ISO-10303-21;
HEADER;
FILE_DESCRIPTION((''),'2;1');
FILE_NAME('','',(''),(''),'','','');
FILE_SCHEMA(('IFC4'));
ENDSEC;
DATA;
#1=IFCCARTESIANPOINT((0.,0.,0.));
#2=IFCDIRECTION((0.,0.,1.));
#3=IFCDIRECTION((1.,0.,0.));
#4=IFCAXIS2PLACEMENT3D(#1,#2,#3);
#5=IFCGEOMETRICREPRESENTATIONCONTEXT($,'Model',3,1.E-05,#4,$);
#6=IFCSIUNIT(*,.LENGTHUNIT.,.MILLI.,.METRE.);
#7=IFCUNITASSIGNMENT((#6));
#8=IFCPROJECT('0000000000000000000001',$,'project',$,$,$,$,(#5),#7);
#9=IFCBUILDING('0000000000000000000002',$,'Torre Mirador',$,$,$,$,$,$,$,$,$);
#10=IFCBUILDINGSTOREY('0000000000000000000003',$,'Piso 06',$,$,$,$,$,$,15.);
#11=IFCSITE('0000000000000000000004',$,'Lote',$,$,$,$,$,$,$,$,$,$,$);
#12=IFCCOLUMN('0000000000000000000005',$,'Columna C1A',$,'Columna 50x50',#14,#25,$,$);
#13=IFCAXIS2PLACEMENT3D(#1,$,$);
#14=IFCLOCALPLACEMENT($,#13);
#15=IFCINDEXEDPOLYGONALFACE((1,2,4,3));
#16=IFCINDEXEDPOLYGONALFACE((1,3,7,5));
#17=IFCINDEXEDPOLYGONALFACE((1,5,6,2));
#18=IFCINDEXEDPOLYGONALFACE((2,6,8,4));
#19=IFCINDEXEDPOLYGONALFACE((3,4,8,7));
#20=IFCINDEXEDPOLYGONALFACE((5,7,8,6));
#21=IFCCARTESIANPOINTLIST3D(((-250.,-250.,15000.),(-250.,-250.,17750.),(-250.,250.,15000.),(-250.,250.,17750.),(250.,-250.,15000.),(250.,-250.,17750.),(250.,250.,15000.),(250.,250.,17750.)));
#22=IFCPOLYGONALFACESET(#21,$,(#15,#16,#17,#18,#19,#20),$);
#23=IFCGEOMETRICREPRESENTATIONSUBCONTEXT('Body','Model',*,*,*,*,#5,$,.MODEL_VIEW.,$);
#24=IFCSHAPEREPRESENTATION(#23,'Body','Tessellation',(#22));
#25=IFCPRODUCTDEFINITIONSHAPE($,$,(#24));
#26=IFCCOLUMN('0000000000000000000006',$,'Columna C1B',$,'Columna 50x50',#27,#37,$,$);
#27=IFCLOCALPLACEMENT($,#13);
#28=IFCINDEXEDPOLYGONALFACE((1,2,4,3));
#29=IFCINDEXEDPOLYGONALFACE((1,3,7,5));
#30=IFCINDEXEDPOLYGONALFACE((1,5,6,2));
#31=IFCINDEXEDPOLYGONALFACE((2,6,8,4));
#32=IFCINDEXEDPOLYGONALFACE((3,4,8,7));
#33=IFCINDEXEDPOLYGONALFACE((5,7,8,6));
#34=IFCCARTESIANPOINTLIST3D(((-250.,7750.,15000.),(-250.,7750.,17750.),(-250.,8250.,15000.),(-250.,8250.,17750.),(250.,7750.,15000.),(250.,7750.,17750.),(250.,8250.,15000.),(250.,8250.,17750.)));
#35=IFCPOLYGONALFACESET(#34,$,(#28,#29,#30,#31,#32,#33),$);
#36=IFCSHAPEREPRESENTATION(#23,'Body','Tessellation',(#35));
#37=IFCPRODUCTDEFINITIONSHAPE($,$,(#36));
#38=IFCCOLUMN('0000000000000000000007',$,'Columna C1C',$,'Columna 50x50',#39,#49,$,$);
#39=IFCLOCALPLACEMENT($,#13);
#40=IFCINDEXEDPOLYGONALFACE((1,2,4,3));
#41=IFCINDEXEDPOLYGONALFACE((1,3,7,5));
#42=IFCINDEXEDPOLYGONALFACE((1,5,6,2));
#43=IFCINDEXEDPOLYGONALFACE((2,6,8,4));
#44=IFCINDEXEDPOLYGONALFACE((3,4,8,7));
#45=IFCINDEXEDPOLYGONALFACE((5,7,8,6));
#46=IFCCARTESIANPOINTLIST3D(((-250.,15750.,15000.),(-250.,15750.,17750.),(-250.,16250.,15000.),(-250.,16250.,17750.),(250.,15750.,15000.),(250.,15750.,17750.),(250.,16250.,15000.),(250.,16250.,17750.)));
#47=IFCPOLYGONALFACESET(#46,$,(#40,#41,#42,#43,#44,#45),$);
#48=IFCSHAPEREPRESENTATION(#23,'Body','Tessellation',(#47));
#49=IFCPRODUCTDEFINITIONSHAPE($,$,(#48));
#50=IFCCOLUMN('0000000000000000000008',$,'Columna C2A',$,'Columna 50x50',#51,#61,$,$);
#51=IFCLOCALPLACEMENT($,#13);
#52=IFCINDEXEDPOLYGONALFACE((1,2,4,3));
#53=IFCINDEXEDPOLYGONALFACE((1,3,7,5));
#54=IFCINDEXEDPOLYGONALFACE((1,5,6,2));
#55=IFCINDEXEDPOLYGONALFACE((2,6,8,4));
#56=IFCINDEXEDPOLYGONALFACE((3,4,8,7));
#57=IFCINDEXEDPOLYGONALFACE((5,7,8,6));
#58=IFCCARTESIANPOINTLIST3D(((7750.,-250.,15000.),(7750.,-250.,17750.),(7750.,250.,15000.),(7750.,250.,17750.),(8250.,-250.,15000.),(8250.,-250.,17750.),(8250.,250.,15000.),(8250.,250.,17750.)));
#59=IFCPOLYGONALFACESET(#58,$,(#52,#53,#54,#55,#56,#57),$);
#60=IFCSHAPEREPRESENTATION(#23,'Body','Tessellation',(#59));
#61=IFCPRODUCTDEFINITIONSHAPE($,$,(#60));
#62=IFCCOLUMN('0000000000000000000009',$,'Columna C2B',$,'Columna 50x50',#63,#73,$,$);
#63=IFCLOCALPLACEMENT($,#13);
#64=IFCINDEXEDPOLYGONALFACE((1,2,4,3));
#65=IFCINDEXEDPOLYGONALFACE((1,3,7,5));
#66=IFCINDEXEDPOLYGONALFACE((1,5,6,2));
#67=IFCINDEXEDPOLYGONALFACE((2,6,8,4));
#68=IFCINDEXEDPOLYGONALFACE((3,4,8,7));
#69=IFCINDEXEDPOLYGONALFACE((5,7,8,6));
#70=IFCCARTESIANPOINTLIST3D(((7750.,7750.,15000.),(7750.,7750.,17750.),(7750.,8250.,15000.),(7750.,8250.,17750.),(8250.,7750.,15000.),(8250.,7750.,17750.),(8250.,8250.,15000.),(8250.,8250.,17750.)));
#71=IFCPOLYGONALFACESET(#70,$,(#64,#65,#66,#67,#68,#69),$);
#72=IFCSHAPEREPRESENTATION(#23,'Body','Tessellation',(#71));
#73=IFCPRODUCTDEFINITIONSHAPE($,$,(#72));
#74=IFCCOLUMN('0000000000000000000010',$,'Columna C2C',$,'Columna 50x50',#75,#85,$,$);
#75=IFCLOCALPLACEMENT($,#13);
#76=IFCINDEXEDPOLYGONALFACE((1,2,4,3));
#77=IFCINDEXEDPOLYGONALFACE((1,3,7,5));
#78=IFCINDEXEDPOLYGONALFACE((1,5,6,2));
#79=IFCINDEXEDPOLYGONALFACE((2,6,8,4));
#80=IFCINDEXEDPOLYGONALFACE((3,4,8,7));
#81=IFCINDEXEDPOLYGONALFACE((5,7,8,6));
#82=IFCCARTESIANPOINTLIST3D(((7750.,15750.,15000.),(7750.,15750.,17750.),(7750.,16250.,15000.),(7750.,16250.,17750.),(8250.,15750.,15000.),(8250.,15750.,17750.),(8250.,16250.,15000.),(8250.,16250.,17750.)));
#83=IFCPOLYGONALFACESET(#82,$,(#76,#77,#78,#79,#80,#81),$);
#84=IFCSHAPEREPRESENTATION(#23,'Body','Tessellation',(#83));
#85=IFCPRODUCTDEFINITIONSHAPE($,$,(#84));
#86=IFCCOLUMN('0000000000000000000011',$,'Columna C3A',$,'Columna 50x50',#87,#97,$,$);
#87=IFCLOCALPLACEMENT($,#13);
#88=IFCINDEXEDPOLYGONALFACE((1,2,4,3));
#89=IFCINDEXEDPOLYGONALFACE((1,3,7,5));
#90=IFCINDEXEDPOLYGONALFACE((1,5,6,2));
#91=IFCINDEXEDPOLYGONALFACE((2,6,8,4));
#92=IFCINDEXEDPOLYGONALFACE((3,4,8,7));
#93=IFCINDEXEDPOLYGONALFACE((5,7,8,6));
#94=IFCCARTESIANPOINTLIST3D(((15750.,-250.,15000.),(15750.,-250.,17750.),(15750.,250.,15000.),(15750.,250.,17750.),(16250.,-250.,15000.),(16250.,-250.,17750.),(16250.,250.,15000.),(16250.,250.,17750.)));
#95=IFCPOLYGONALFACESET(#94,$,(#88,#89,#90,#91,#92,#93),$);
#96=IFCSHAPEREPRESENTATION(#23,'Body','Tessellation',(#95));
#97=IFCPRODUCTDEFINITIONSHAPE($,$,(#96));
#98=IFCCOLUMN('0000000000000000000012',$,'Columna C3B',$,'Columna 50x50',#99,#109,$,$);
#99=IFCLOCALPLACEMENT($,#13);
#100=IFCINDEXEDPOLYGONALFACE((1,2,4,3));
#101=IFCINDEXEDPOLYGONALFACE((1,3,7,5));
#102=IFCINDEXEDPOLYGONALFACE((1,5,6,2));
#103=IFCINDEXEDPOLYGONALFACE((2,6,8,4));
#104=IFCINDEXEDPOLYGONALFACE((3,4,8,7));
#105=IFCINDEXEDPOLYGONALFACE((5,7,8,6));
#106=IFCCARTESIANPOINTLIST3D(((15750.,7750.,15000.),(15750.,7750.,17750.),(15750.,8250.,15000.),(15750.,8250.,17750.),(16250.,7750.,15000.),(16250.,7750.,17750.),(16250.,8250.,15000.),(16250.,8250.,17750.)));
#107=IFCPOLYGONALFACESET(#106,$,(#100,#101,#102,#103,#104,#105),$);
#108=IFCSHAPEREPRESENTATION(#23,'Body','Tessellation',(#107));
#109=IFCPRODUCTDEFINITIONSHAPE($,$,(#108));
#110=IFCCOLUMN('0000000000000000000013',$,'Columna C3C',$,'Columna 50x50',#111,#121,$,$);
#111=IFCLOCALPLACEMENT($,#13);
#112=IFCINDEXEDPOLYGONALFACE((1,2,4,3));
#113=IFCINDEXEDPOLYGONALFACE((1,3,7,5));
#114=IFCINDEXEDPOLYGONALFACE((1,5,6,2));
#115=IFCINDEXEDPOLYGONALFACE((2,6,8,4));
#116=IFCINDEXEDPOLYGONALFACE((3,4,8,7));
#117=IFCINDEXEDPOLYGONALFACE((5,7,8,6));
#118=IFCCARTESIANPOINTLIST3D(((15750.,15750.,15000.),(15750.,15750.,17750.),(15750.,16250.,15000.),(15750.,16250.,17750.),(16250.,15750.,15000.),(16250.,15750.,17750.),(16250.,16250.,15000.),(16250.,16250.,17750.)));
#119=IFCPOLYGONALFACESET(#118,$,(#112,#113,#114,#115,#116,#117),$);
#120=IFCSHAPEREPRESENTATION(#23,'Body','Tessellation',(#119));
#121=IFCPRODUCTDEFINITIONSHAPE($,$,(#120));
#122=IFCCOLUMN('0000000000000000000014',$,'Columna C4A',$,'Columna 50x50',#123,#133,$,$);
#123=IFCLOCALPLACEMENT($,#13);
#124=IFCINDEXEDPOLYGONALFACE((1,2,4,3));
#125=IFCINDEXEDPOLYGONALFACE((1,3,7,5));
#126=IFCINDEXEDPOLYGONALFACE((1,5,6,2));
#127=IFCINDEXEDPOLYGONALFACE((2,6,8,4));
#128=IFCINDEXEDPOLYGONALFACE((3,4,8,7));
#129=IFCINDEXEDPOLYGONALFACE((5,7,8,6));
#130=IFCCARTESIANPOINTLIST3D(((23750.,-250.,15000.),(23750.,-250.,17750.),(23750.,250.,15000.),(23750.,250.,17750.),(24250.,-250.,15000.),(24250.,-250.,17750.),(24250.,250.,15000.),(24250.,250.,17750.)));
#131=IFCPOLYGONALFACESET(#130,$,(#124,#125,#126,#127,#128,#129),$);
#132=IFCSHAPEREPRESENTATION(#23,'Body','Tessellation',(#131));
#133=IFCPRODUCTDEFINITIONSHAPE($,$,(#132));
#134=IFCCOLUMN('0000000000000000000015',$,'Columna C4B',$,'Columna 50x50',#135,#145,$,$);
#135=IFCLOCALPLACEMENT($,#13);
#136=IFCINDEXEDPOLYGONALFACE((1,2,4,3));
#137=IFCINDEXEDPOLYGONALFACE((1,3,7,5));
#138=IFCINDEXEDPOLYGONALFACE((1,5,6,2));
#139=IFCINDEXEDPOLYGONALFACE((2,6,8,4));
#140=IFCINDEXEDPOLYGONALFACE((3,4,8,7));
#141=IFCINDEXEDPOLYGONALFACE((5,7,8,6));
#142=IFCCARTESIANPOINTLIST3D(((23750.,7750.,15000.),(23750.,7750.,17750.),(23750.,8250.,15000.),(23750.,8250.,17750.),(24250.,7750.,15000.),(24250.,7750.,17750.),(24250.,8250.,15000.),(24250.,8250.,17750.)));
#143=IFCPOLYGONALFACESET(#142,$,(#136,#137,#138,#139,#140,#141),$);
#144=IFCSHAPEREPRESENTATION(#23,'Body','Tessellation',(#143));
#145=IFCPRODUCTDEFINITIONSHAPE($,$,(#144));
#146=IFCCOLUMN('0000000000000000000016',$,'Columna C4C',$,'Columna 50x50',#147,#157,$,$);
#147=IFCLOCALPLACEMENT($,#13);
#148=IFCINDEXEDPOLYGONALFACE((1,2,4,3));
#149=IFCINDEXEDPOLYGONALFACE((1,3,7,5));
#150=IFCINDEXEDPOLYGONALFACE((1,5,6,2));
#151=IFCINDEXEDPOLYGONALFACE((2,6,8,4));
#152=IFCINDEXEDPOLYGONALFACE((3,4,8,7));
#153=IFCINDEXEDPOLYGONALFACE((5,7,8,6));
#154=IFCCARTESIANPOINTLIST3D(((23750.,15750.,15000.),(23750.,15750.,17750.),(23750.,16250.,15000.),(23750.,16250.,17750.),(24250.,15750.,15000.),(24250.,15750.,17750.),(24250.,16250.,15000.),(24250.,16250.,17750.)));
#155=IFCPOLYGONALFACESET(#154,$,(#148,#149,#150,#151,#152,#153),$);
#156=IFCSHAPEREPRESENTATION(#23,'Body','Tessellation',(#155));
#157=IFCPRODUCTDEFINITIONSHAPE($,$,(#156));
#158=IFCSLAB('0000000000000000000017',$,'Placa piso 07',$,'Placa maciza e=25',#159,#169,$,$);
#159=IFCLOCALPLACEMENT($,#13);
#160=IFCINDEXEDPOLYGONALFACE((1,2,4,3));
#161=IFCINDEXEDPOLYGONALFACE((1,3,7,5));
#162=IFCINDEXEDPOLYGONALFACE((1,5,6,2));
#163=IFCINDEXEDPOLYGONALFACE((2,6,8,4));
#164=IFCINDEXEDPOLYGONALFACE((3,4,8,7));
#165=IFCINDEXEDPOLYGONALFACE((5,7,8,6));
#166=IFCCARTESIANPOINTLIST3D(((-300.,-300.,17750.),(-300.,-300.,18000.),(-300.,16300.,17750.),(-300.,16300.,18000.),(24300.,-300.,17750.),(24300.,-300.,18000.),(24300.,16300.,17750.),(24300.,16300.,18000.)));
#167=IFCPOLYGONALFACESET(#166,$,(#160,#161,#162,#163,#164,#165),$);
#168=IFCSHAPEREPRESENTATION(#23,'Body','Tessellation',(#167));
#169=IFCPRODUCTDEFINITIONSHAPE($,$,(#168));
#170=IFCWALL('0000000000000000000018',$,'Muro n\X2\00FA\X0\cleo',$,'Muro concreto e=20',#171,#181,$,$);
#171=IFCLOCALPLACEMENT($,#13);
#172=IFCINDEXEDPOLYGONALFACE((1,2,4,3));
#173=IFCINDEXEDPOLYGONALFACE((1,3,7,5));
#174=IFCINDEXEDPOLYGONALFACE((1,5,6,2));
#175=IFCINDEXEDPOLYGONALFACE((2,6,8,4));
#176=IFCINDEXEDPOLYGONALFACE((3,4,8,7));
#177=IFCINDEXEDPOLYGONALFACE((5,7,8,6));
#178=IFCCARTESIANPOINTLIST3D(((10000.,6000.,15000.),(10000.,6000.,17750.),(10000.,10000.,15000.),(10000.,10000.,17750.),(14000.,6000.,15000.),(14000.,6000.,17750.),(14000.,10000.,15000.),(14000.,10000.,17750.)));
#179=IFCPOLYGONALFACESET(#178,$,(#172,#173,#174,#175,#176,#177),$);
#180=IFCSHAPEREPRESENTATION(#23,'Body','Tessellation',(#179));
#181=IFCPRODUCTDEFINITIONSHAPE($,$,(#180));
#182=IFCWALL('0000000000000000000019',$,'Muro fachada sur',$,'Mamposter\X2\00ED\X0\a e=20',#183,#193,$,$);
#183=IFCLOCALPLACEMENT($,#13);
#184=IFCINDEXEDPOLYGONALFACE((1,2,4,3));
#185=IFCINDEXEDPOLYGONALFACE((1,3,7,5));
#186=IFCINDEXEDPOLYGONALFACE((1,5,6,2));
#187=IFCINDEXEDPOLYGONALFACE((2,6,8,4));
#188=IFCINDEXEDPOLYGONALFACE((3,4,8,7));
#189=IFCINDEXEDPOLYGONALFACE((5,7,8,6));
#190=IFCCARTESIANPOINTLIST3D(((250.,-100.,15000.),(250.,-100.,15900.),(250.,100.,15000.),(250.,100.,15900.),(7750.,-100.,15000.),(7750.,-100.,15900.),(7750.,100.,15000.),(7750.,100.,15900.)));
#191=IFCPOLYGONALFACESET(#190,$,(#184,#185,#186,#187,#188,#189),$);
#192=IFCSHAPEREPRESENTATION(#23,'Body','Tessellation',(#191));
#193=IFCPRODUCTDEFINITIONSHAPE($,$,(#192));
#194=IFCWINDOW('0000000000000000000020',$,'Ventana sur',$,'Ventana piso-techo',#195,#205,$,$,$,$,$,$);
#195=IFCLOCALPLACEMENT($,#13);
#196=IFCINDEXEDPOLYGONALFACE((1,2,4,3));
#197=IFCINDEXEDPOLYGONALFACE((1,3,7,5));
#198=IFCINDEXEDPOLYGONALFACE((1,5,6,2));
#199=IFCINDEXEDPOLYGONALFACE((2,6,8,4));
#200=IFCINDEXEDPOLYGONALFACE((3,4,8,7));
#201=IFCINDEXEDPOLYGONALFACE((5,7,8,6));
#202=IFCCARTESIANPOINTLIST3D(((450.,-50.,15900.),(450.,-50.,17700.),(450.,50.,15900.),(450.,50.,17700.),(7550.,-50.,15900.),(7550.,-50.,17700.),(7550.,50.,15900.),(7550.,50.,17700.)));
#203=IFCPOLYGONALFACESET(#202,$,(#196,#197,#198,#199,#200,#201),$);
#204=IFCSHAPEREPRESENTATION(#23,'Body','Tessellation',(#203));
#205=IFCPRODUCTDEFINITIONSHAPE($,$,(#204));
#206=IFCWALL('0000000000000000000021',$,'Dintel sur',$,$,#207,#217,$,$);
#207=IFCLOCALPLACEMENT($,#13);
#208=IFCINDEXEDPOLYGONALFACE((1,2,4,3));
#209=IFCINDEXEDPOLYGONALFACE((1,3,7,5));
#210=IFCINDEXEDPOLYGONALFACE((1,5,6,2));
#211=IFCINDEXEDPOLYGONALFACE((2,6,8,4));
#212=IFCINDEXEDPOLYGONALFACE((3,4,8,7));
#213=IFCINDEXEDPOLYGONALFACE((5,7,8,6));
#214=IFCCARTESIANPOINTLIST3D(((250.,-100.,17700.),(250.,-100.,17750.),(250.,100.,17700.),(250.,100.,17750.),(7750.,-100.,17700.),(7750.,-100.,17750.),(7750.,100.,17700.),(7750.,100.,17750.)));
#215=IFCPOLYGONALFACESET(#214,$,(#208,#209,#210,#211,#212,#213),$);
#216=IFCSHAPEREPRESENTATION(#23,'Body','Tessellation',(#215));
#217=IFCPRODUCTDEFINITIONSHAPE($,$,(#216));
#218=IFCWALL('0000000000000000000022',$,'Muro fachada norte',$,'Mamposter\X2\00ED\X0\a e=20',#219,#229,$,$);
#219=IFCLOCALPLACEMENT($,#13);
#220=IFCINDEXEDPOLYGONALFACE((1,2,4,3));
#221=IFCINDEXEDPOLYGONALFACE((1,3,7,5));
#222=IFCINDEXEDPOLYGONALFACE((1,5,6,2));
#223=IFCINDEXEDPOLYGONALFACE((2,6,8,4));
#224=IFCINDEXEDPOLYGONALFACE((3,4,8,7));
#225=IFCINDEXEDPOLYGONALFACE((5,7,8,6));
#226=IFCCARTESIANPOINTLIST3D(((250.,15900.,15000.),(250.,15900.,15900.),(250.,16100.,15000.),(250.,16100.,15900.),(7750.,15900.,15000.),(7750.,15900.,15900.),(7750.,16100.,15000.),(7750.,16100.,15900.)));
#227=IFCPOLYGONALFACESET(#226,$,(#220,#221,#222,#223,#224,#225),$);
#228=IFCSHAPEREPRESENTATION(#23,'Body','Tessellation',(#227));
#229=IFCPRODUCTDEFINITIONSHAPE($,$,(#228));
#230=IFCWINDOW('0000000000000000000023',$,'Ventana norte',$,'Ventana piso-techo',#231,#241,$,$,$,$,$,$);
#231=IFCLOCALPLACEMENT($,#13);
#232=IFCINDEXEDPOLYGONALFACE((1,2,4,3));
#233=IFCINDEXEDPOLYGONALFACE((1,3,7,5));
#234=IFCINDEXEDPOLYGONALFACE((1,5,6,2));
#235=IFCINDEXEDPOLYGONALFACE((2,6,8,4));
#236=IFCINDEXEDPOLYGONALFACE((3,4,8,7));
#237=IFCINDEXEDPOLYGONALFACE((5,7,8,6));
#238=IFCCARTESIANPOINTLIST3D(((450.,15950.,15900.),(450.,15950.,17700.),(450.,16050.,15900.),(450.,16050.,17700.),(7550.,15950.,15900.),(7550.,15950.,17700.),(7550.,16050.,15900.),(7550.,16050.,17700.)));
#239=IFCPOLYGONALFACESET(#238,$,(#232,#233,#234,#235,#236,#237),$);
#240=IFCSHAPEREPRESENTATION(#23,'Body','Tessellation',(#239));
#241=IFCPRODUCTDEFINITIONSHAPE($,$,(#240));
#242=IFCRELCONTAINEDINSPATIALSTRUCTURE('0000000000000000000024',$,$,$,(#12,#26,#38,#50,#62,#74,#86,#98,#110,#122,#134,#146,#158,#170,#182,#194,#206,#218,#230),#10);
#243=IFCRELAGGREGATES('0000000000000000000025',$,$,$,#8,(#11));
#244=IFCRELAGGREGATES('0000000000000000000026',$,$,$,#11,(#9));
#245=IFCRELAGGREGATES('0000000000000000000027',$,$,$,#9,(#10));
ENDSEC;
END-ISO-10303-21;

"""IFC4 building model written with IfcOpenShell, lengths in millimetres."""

from ifc_helpers import new_model, si_unit, frame, origin_with_axes, place, context, subcontext, project, spatial, indexed_curve, outline, extrude, element, save


model = new_model("IFC4")

# Units and contexts
model_context = context("Model", 3, precision=1e-05, world=origin_with_axes())
body_context = subcontext(model_context, "Body", "Model", "MODEL_VIEW")
ifc_project = project(units=[si_unit("LENGTHUNIT", "METRE", prefix="MILLI")], contexts=[model_context])

# Site, building, storey
site = spatial("IfcSite", under=ifc_project, Name="Lote")
building = spatial("IfcBuilding", under=site, Name="Torre Mirador")
storey = spatial("IfcBuildingStorey", under=building, Name="Piso 06", Elevation=15.0)

# Columns
for number, where, z_axis, x_axis, name in (
    (1, (-250.0, -250.0, 15000.0), (0.0, 0.0, 1.0), (1.0, 0.0, 0.0), "Columna C1A"),
    (2, (-250.0, 7750.0, 15000.0), (0.0, 0.0, 1.0), (1.0, 0.0, 0.0), "Columna C1B"),
    (3, (-250.0, 15750.0, 15000.0), (0.0, 0.0, 1.0), (1.0, 0.0, 0.0), "Columna C1C"),
    (4, (7750.0, -250.0, 15000.0), (0.0, 0.0, 1.0), (1.0, 0.0, 0.0), "Columna C2A"),
    (5, (7750.0, 7750.0, 15000.0), (0.0, 0.0, 1.0), (1.0, 0.0, 0.0), "Columna C2B"),
    (6, (7750.0, 15750.0, 15000.0), (0.0, 0.0, 1.0), (1.0, 0.0, 0.0), "Columna C2C"),
    (7, (15750.0, -250.0, 15000.0), (0.0, 0.0, 1.0), (1.0, 0.0, 0.0), "Columna C3A"),
    (8, (15750.0, 7750.0, 15000.0), (0.0, 0.0, 1.0), (1.0, 0.0, 0.0), "Columna C3B"),
    (9, (15750.0, 15750.0, 15000.0), (0.0, 0.0, 1.0), (1.0, 0.0, 0.0), "Columna C3C"),
    (10, (23750.0, -250.0, 15000.0), (0.0, 0.0, 1.0), (1.0, 0.0, 0.0), "Columna C4A"),
    (11, (23750.0, 7750.0, 15000.0), (0.0, 0.0, 1.0), (1.0, 0.0, 0.0), "Columna C4B"),
    (12, (23750.0, 15750.0, 15000.0), (0.0, 0.0, 1.0), (1.0, 0.0, 0.0), "Columna C4C"),
):
    element("IfcColumn", number, at=place(None, frame(where, z_axis=z_axis, x_axis=x_axis)), inside=storey, Name=name, ObjectType="Columna 50x50", context=body_context, shape_type="SweptSolid", body=[
        extrude(outline(indexed_curve([(0.0, 0.0), (0.0, 500.0), (500.0, 500.0), (500.0, 0.0), (0.0, 0.0)], self_intersect=False)), origin_with_axes(), (0.0, 0.0, 1.0), 2750.0),
    ])

# Slab
slab_placement = place(None, frame((-300.0, -300.0, 17750.0), z_axis=(0.0, 0.0, 1.0), x_axis=(1.0, 0.0, 0.0)))
element("IfcSlab", 13, at=slab_placement, inside=storey, Name="Placa piso 07", ObjectType="Placa maciza e=25", context=body_context, shape_type="SweptSolid", body=[
    extrude(outline(indexed_curve([(0.0, 0.0), (0.0, 16600.0), (24600.0, 16600.0), (24600.0, 0.0), (0.0, 0.0)], self_intersect=False)), origin_with_axes(), (0.0, 0.0, 1.0), 250.0),
])

# Walls
wall_1_placement = place(None, frame((10000.0, 6000.0, 15000.0), z_axis=(0.0, 0.0, 1.0), x_axis=(1.0, 0.0, 0.0)))
element("IfcWall", 14, at=wall_1_placement, inside=storey, Name="Muro núcleo", ObjectType="Muro concreto e=20", context=body_context, shape_type="SweptSolid", body=[
    extrude(outline(indexed_curve([(0.0, 0.0), (0.0, 4000.0), (4000.0, 4000.0), (4000.0, 0.0), (0.0, 0.0)], self_intersect=False)), origin_with_axes(), (0.0, 0.0, 1.0), 2750.0),
])
wall_2_placement = place(None, frame((250.0, -100.0, 15000.0), z_axis=(0.0, 0.0, 1.0), x_axis=(1.0, 0.0, 0.0)))
element("IfcWall", 15, at=wall_2_placement, inside=storey, Name="Muro fachada sur", ObjectType="Mampostería e=20", context=body_context, shape_type="SweptSolid", body=[
    extrude(outline(indexed_curve([(0.0, 0.0), (0.0, 200.0), (7500.0, 200.0), (7500.0, 0.0), (0.0, 0.0)], self_intersect=False)), origin_with_axes(), (0.0, 0.0, 1.0), 900.0),
])

# Window
window_1_placement = place(None, frame((450.0, -50.0, 15900.0), z_axis=(0.0, 0.0, 1.0), x_axis=(1.0, 0.0, 0.0)))
element("IfcWindow", 16, at=window_1_placement, inside=storey, Name="Ventana sur", ObjectType="Ventana piso-techo", context=body_context, shape_type="SweptSolid", body=[
    extrude(outline(indexed_curve([(0.0, 0.0), (0.0, 100.0), (7100.0, 100.0), (7100.0, 0.0), (0.0, 0.0)], self_intersect=False)), origin_with_axes(), (0.0, 0.0, 1.0), 1800.0),
])

# Walls
wall_3_placement = place(None, frame((250.0, -100.0, 17700.0), z_axis=(0.0, 0.0, 1.0), x_axis=(1.0, 0.0, 0.0)))
element("IfcWall", 17, at=wall_3_placement, inside=storey, Name="Dintel sur", context=body_context, shape_type="SweptSolid", body=[
    extrude(outline(indexed_curve([(0.0, 0.0), (0.0, 200.0), (7500.0, 200.0), (7500.0, 0.0), (0.0, 0.0)], self_intersect=False)), origin_with_axes(), (0.0, 0.0, 1.0), 50.0),
])
wall_4_placement = place(None, frame((250.0, 15900.0, 15000.0), z_axis=(0.0, 0.0, 1.0), x_axis=(1.0, 0.0, 0.0)))
element("IfcWall", 18, at=wall_4_placement, inside=storey, Name="Muro fachada norte", ObjectType="Mampostería e=20", context=body_context, shape_type="SweptSolid", body=[
    extrude(outline(indexed_curve([(0.0, 0.0), (0.0, 200.0), (7500.0, 200.0), (7500.0, 0.0), (0.0, 0.0)], self_intersect=False)), origin_with_axes(), (0.0, 0.0, 1.0), 900.0),
])

# Window
window_2_placement = place(None, frame((450.0, 15950.0, 15900.0), z_axis=(0.0, 0.0, 1.0), x_axis=(1.0, 0.0, 0.0)))
element("IfcWindow", 19, at=window_2_placement, inside=storey, Name="Ventana norte", ObjectType="Ventana piso-techo", context=body_context, shape_type="SweptSolid", body=[
    extrude(outline(indexed_curve([(0.0, 0.0), (0.0, 100.0), (7100.0, 100.0), (7100.0, 0.0), (0.0, 0.0)], self_intersect=False)), origin_with_axes(), (0.0, 0.0, 1.0), 1800.0),
])

save(model, "model.ifc")
